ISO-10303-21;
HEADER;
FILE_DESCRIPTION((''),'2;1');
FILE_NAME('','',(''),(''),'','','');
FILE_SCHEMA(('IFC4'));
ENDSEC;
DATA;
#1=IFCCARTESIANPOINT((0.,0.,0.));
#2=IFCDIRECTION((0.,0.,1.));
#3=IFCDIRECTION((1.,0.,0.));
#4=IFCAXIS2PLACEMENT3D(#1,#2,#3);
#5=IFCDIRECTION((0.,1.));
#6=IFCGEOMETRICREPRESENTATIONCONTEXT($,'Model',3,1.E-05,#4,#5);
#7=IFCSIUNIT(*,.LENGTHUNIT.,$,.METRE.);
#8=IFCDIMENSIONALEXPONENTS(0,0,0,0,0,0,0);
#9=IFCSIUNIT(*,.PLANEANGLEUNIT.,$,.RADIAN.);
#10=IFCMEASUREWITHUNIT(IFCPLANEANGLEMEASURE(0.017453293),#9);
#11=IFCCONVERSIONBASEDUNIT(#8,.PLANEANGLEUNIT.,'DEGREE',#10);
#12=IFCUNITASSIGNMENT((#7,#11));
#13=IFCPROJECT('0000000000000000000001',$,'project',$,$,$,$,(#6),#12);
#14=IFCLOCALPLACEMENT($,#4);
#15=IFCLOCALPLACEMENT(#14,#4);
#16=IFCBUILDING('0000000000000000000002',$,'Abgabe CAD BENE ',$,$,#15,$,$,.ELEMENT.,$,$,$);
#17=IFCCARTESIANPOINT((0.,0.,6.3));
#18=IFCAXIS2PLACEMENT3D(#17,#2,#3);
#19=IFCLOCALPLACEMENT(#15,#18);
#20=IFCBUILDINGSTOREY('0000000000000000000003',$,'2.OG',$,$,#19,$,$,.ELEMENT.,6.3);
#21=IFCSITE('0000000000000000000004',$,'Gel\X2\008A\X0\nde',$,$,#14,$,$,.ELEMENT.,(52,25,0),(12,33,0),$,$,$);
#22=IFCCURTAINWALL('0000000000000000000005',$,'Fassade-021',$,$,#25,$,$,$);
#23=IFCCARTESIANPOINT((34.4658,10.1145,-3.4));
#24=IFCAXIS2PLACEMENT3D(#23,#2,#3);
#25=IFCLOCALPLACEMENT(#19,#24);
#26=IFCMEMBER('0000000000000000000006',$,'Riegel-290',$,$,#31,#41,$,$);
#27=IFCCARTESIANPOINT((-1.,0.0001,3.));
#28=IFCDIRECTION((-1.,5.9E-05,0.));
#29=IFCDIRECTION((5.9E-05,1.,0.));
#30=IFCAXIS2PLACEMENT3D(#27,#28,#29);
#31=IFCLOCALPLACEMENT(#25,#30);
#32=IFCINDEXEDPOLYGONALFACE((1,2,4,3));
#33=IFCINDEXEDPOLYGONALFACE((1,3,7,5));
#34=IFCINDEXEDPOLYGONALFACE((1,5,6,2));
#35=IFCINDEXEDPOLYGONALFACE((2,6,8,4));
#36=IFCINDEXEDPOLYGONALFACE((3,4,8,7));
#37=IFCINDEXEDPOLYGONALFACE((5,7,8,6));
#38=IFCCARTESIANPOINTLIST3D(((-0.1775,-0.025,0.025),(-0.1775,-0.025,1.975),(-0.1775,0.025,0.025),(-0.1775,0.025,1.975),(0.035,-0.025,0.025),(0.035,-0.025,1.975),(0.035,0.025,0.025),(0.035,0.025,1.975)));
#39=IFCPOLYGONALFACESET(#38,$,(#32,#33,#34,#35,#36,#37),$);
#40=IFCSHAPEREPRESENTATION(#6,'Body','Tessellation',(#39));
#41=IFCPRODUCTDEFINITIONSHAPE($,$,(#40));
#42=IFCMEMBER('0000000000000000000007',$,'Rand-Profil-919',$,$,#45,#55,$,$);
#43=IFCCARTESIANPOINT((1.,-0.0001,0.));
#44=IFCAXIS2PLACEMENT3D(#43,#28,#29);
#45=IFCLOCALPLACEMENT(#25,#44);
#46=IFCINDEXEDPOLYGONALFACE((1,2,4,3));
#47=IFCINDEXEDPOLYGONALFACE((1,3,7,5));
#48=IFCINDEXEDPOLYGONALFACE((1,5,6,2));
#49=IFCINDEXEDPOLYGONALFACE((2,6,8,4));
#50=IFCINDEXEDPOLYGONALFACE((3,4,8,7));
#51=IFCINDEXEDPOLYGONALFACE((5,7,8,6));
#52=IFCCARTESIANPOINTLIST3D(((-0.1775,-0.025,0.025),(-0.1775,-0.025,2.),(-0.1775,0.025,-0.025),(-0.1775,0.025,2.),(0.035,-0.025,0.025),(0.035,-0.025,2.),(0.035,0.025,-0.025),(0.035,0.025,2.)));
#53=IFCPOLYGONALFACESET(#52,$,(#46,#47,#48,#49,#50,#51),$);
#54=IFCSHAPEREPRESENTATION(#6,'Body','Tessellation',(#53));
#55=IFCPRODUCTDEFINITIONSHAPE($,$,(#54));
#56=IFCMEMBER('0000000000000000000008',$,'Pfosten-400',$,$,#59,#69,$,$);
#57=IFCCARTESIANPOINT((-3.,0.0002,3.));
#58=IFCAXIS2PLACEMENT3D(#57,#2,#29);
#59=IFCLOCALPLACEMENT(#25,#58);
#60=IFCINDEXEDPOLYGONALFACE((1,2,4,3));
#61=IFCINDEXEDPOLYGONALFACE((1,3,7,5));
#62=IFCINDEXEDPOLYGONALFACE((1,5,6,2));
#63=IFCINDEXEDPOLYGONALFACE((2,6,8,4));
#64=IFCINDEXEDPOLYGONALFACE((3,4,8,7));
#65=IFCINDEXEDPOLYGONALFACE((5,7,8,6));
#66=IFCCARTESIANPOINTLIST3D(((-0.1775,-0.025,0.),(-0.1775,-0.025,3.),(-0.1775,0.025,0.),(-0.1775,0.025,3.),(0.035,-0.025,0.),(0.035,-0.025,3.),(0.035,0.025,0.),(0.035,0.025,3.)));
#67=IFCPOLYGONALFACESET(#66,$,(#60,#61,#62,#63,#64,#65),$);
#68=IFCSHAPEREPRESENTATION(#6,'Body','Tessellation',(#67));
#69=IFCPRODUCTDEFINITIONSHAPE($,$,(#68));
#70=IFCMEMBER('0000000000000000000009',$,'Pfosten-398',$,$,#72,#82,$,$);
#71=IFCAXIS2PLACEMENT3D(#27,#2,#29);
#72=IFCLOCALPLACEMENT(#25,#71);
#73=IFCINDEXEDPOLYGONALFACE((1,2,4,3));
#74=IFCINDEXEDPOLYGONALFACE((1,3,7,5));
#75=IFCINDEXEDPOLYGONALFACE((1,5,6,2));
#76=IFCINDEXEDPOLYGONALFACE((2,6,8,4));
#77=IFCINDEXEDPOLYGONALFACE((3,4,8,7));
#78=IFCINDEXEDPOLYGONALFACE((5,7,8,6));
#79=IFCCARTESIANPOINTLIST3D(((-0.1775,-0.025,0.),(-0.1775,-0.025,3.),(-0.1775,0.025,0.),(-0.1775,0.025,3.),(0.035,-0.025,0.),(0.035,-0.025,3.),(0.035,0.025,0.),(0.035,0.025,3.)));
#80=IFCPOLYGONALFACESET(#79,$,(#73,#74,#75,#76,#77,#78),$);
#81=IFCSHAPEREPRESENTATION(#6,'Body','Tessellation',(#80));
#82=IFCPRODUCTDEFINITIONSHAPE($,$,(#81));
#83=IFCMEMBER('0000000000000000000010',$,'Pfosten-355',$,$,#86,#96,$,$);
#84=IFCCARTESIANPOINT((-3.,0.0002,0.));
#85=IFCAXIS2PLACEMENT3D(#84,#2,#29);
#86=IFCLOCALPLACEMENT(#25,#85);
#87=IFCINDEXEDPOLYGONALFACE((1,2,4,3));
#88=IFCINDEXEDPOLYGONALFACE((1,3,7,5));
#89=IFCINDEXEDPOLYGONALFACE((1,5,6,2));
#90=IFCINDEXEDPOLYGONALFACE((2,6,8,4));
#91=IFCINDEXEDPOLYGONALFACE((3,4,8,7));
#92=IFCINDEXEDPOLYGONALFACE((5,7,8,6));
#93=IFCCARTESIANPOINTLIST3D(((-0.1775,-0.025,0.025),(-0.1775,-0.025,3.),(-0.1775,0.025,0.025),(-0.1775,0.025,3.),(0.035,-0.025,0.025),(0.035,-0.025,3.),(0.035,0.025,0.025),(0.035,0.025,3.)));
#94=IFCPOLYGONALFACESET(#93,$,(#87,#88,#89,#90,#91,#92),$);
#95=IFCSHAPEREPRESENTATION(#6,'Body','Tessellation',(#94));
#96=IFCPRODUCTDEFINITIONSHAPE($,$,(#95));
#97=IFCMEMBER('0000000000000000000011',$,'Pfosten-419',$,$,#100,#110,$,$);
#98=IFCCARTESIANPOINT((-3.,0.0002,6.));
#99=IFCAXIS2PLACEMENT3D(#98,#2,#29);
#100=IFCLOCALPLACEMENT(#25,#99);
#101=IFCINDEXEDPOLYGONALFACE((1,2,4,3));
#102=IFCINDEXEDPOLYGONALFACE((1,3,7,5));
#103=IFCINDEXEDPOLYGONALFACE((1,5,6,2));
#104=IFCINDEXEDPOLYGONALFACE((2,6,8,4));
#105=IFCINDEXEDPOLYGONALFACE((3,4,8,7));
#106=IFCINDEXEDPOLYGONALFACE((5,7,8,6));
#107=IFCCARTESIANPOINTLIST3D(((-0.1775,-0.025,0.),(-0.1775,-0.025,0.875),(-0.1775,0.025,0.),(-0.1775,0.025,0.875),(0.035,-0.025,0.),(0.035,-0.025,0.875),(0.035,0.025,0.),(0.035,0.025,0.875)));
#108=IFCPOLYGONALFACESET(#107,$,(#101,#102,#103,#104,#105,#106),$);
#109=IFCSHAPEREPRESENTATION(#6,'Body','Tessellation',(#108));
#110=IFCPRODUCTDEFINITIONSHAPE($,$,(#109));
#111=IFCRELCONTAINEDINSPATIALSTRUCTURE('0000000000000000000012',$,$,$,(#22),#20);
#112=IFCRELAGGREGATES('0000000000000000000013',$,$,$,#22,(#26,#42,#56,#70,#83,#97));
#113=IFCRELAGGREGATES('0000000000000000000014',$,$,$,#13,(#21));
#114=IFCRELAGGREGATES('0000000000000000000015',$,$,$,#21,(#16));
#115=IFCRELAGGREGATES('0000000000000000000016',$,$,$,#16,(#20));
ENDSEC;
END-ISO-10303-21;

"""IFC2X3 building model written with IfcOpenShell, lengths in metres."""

from ifc_helpers import new_model, entity, si_unit, converted_unit, direction, frame, origin_with_axes, place, context, project, spatial, polyline, outline, extrude, clip, halfspace, element, aggregate, save


model = new_model("IFC2X3")

# Units and contexts
model_context = context("Model", 3, precision=1e-05, world=origin_with_axes(), true_north=direction((0.0, 1.0)))
ifc_project = project(units=[si_unit("LENGTHUNIT", "METRE"), converted_unit("PLANEANGLEUNIT", "DEGREE", entity("IfcPlaneAngleMeasure", 0.017453293), si_unit("PLANEANGLEUNIT", "RADIAN"), dimensions=[0, 0, 0, 0, 0, 0, 0])], contexts=[model_context])

# Site, building, storey
site_placement = place(None, origin_with_axes())
site = spatial("IfcSite", under=ifc_project, at=site_placement, Name="Gel\u008ande", CompositionType="ELEMENT", RefLatitude=(52, 25, 0), RefLongitude=(12, 33, 0))
building_placement = place(site_placement, origin_with_axes())
building = spatial("IfcBuilding", under=site, at=building_placement, Name="Abgabe CAD BENE ", CompositionType="ELEMENT")
storey_placement = place(building_placement, frame((0.0, 0.0, 6.3), z_axis=(0.0, 0.0, 1.0), x_axis=(1.0, 0.0, 0.0)))
storey = spatial("IfcBuildingStorey", under=building, at=storey_placement, Name="2.OG", CompositionType="ELEMENT", Elevation=6.3)

# Curtain wall, members
curtain_wall_placement = place(storey_placement, frame((34.4658, 10.1145, -3.4), z_axis=(0.0, 0.0, 1.0), x_axis=(1.0, 0.0, 0.0)))
curtain_wall = element("IfcCurtainWall", 1, at=curtain_wall_placement, inside=storey, Name="Fassade-021")
member_1_placement = place(curtain_wall_placement, frame((-1.0, 0.0001, 3.0), z_axis=(-1.0, 0.000059, 0.0), x_axis=(0.000059, 1.0, 0.0)))
member_1 = element("IfcMember", 2, at=member_1_placement, Name="Riegel-290", context=model_context, shape_type="SweptSolid", body=[
    extrude(outline(polyline([(-0.1775, -0.025), (0.035, -0.025), (0.035, 0.025), (-0.1775, 0.025), (-0.1775, -0.025)])), frame((0.0, 0.0, 0.025), z_axis=(0.0, 0.0, 1.0), x_axis=(1.0, 0.0, 0.0)), (0.0, 0.0, 1.0), 1.95),
])
member_2_placement = place(curtain_wall_placement, frame((1.0, -0.0001, 0.0), z_axis=(-1.0, 0.000059, 0.0), x_axis=(0.000059, 1.0, 0.0)))
member_2 = element("IfcMember", 3, at=member_2_placement, Name="Rand-Profil-919", context=model_context, shape_type="Clipping", body=[
    clip(extrude(outline(polyline([(-0.1775, -0.025), (0.035, -0.025), (0.035, 0.025), (-0.1775, 0.025), (-0.1775, -0.025)])), frame((0.0, 0.0, -0.025), z_axis=(0.0, 0.0, 1.0), x_axis=(1.0, 0.0, 0.0)), (0.0, 0.0, 1.0), 2.025), halfspace(frame((0.0, 0.0, 0.0), z_axis=(0.0, 0.707107, 0.707107), x_axis=(0.0, 0.707107, -0.707107)), True)),
])
member_3_placement = place(curtain_wall_placement, frame((-3.0, 0.0002, 3.0), z_axis=(0.0, 0.0, 1.0), x_axis=(0.000059, 1.0, 0.0)))
member_3 = element("IfcMember", 4, at=member_3_placement, Name="Pfosten-400", context=model_context, shape_type="SweptSolid", body=[
    extrude(outline(polyline([(0.025, -0.1775), (0.025, 0.035), (-0.025, 0.035), (-0.025, -0.1775), (0.025, -0.1775)])), frame((0.0, 0.0, 0.0), z_axis=(0.0, 0.0, 1.0), x_axis=(0.000059, -1.0, 0.0)), (0.0, 0.0, 1.0), 3.0),
])
member_4_placement = place(curtain_wall_placement, frame((-1.0, 0.0001, 3.0), z_axis=(0.0, 0.0, 1.0), x_axis=(0.000059, 1.0, 0.0)))
member_4 = element("IfcMember", 5, at=member_4_placement, Name="Pfosten-398", context=model_context, shape_type="SweptSolid", body=[
    extrude(outline(polyline([(0.025, -0.1775), (0.025, 0.035), (-0.025, 0.035), (-0.025, -0.1775), (0.025, -0.1775)])), frame((0.0, 0.0, 0.0), z_axis=(0.0, 0.0, 1.0), x_axis=(0.000059, -1.0, 0.0)), (0.0, 0.0, 1.0), 3.0),
])
member_5_placement = place(curtain_wall_placement, frame((-3.0, 0.0002, 0.0), z_axis=(0.0, 0.0, 1.0), x_axis=(0.000059, 1.0, 0.0)))
member_5 = element("IfcMember", 6, at=member_5_placement, Name="Pfosten-355", context=model_context, shape_type="SweptSolid", body=[
    extrude(outline(polyline([(0.025, -0.1775), (0.025, 0.035), (-0.025, 0.035), (-0.025, -0.1775), (0.025, -0.1775)])), frame((0.0, 0.0, 0.025), z_axis=(0.0, 0.0, 1.0), x_axis=(0.000059, -1.0, 0.0)), (0.0, 0.0, 1.0), 2.975),
])
member_6_placement = place(curtain_wall_placement, frame((-3.0, 0.0002, 6.0), z_axis=(0.0, 0.0, 1.0), x_axis=(0.000059, 1.0, 0.0)))
member_6 = element("IfcMember", 7, at=member_6_placement, Name="Pfosten-419", context=model_context, shape_type="SweptSolid", body=[
    extrude(outline(polyline([(0.025, -0.1775), (0.025, 0.035), (-0.025, 0.035), (-0.025, -0.1775), (0.025, -0.1775)])), frame((0.0, 0.0, 0.0), z_axis=(0.0, 0.0, 1.0), x_axis=(0.000059, -1.0, 0.0)), (0.0, 0.0, 1.0), 0.875),
])
aggregate(curtain_wall, [member_1, member_2, member_3, member_4, member_5, member_6])

save(model, "model.ifc")
